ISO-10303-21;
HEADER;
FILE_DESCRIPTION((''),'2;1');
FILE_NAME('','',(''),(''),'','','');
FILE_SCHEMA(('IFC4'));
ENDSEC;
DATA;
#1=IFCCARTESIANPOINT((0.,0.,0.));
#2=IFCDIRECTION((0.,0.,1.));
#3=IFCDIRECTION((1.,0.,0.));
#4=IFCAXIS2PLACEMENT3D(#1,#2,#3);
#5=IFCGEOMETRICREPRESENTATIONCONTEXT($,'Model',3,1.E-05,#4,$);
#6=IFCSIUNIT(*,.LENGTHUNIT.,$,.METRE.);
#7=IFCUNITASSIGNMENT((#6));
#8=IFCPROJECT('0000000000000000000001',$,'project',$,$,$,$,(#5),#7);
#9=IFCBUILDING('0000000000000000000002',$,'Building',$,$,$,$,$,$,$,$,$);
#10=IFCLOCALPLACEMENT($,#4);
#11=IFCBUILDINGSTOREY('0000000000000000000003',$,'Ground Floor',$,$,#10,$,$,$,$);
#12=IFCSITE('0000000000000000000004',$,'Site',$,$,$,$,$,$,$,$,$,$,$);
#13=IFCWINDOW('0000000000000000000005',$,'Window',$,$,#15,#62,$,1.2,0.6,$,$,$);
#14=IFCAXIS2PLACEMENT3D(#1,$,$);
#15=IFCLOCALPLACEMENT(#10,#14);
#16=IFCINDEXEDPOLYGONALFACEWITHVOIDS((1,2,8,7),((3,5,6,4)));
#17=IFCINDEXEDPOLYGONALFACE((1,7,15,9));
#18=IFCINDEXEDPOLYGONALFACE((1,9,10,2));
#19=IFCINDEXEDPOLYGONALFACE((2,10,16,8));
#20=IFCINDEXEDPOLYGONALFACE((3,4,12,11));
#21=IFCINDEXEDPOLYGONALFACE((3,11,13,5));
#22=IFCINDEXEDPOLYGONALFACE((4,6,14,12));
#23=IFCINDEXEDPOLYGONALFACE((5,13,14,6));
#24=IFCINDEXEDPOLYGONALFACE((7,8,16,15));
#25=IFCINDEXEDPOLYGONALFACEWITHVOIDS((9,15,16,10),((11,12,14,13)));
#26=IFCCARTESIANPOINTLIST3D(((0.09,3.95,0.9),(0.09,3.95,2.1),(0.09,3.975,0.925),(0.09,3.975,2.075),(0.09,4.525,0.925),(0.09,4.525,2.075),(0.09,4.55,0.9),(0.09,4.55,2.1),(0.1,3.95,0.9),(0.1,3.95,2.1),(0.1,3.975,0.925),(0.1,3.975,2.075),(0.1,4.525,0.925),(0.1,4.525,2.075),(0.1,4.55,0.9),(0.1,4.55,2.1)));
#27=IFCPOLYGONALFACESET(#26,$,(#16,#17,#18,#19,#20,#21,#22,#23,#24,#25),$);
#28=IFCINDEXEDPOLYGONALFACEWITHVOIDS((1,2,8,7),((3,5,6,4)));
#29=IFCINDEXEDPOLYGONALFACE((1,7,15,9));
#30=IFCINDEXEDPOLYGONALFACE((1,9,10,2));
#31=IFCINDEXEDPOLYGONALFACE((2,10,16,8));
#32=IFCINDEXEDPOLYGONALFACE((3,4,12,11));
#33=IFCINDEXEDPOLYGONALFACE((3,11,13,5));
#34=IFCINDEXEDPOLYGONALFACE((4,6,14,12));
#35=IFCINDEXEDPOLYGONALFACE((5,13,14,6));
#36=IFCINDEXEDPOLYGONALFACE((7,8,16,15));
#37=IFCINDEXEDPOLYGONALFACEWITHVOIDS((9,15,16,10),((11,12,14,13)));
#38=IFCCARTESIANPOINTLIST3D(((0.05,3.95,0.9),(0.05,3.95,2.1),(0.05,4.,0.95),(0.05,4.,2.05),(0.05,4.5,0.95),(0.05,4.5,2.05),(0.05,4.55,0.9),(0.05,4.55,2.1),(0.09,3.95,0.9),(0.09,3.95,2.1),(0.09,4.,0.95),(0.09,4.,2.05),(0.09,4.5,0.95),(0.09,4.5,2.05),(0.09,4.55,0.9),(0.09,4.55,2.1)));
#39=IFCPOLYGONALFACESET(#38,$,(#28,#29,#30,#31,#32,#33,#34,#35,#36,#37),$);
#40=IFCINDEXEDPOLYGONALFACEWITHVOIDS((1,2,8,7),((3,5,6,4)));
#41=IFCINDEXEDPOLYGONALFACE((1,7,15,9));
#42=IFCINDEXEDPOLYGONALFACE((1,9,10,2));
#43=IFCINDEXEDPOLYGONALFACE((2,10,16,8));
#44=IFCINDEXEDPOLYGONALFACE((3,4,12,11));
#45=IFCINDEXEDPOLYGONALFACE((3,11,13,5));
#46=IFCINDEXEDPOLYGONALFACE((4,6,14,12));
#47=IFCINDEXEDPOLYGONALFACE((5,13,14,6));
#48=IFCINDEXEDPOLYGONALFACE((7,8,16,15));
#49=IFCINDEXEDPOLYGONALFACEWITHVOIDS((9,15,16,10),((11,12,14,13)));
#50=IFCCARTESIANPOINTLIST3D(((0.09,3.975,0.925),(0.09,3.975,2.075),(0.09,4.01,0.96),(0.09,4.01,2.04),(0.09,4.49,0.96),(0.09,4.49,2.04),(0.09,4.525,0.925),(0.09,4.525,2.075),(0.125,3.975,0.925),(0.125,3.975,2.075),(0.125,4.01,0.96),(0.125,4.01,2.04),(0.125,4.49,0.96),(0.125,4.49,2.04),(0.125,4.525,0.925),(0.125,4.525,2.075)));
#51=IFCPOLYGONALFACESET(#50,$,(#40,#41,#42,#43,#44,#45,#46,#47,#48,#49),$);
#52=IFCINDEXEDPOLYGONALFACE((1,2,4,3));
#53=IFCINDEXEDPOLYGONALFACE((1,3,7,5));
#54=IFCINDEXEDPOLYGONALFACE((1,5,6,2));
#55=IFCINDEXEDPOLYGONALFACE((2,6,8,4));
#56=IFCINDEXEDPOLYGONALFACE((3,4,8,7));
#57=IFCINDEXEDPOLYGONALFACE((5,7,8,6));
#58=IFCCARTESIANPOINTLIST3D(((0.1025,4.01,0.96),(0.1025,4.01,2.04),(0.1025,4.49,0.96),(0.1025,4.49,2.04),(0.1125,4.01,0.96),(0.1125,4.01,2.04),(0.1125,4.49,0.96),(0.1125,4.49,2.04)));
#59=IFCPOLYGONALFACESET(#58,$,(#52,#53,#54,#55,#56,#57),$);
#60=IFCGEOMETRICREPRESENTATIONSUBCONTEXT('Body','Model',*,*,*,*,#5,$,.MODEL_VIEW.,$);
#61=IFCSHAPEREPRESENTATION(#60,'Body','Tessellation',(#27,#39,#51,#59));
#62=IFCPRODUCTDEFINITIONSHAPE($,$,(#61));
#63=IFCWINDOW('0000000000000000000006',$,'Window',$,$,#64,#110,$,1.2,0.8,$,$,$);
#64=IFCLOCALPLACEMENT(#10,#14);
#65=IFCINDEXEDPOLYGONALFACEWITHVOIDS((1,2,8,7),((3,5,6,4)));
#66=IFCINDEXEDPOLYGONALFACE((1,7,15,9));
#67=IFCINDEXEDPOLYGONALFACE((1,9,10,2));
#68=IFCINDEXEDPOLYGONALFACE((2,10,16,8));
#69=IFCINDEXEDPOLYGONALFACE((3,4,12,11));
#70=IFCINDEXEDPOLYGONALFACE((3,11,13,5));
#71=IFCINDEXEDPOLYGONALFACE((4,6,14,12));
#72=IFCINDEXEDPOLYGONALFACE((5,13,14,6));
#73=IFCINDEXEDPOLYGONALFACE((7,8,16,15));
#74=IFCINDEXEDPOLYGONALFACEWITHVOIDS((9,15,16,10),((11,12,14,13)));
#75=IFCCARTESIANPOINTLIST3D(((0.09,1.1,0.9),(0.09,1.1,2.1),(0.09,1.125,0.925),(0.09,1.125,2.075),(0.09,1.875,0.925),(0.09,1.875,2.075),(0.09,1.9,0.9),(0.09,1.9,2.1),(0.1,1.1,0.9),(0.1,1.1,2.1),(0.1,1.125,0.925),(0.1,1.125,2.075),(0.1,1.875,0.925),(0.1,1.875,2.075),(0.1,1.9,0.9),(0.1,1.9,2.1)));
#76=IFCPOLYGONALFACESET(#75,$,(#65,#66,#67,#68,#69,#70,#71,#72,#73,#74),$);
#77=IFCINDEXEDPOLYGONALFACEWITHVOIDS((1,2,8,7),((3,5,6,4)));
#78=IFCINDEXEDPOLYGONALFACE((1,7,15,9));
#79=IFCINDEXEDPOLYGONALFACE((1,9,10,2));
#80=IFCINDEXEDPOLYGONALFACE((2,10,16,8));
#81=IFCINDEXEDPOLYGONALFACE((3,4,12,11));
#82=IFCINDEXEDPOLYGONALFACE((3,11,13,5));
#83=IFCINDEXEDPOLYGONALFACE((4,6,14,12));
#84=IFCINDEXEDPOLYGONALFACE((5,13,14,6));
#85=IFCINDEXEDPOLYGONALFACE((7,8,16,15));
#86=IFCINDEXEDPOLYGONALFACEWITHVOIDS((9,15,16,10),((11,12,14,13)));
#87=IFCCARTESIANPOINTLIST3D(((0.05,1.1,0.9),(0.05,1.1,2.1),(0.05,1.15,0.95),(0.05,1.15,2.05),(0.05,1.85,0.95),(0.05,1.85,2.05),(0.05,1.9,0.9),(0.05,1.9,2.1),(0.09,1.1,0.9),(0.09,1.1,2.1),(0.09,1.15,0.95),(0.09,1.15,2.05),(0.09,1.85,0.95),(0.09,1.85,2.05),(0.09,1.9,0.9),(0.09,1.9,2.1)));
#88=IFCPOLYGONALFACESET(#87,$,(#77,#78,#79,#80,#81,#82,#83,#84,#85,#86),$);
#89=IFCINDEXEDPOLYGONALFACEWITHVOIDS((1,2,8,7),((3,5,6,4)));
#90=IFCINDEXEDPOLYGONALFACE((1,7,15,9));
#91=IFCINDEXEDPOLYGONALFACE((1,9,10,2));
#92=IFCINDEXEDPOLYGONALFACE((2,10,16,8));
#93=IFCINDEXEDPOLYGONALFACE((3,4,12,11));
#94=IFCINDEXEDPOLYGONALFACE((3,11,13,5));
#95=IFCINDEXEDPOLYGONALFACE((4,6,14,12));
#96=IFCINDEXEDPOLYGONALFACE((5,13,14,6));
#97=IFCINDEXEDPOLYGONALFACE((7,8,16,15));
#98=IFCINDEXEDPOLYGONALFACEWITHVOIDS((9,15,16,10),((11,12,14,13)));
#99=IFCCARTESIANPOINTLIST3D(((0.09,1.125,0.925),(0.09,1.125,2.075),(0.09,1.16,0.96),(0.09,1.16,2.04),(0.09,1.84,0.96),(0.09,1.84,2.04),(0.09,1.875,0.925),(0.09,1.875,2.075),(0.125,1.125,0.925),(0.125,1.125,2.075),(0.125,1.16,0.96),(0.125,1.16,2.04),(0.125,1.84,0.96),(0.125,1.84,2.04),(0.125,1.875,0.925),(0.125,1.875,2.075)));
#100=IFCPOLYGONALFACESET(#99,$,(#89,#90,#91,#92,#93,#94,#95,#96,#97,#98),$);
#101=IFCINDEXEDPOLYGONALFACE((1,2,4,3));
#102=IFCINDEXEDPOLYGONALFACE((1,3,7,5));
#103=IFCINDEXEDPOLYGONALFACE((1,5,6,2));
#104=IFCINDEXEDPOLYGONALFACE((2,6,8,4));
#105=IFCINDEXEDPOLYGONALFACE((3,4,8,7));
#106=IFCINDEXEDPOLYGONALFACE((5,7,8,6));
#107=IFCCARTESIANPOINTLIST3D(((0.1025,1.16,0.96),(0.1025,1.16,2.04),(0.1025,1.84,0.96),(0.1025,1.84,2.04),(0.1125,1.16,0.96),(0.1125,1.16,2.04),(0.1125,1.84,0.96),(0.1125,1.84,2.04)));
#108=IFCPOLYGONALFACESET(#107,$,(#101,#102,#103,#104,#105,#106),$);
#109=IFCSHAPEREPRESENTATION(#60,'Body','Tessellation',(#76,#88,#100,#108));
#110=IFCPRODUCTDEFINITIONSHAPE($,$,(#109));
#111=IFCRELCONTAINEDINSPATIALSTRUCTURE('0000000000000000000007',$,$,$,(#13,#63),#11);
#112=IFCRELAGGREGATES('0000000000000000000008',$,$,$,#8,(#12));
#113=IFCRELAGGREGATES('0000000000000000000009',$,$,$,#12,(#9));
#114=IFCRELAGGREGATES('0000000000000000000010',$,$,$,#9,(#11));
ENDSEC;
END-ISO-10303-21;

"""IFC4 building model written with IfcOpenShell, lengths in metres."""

from ifc_helpers import new_model, si_unit, frame, origin_with_axes, place, context, subcontext, project, spatial, line, indexed_curve, outline, extrude, element, save


model = new_model("IFC4")

# Units and contexts
model_context = context("Model", 3, precision=1e-05, world=origin_with_axes())
body_context = subcontext(model_context, "Body", "Model", "MODEL_VIEW")
ifc_project = project(units=[si_unit("LENGTHUNIT", "METRE")], contexts=[model_context])

# Site, building, storey
site = spatial("IfcSite", under=ifc_project, Name="Site")
building = spatial("IfcBuilding", under=site, Name="Building")
storey_placement = place(None, origin_with_axes())
storey = spatial("IfcBuildingStorey", under=building, at=storey_placement, Name="Ground Floor")

# Windows
window_1_placement = place(storey_placement, frame((0.0, 4.55, 0.9), z_axis=(0.0, 0.0, 1.0), x_axis=(0.0, -1.0, 0.0)))
element("IfcWindow", 1, at=window_1_placement, inside=storey, Name="Window", OverallHeight=1.2, OverallWidth=0.6, context=body_context, shape_type="SweptSolid", body=[
    extrude(outline(indexed_curve([(0.0, 0.0), (0.6, 0.0), (0.6, 1.2), (0.0, 1.2)], segments=[line(1, 2, 3, 4, 1)]), holes=[indexed_curve([(0.025, 0.025), (0.575, 0.025), (0.575, 1.175), (0.025, 1.175)], segments=[line(1, 2, 3, 4, 1)])]), frame((0.0, 0.09, 0.0), z_axis=(0.0, -1.0, 0.0), x_axis=(1.0, 0.0, 0.0)), (0.0, 0.0, -1.0), 0.01),
    extrude(outline(indexed_curve([(0.0, 0.0), (0.6, 0.0), (0.6, 1.2), (0.0, 1.2)], segments=[line(1, 2, 3, 4, 1)]), holes=[indexed_curve([(0.05, 0.05), (0.55, 0.05), (0.55, 1.15), (0.05, 1.15)], segments=[line(1, 2, 3, 4, 1)])]), frame((0.0, 0.05, 0.0), z_axis=(0.0, -1.0, 0.0), x_axis=(1.0, 0.0, 0.0)), (0.0, 0.0, -1.0), 0.04),
    extrude(outline(indexed_curve([(0.0, 0.0), (0.55, 0.0), (0.55, 1.15), (0.0, 1.15)], segments=[line(1, 2, 3, 4, 1)]), holes=[indexed_curve([(0.035, 0.035), (0.515, 0.035), (0.515, 1.115), (0.035, 1.115)], segments=[line(1, 2, 3, 4, 1)])]), frame((0.025, 0.09, 0.025), z_axis=(0.0, -1.0, 0.0), x_axis=(1.0, 0.0, 0.0)), (0.0, 0.0, -1.0), 0.035),
    extrude(outline(indexed_curve([(0.035, 0.035), (0.515, 0.035), (0.515, 1.115), (0.035, 1.115)], segments=[line(1, 2, 3, 4, 1)])), frame((0.025, 0.1025, 0.025), z_axis=(0.0, -1.0, 0.0), x_axis=(1.0, 0.0, 0.0)), (0.0, 0.0, -1.0), 0.01),
])
window_2_placement = place(storey_placement, frame((0.0, 1.9, 0.9), z_axis=(0.0, 0.0, 1.0), x_axis=(0.0, -1.0, 0.0)))
element("IfcWindow", 2, at=window_2_placement, inside=storey, Name="Window", OverallHeight=1.2, OverallWidth=0.8, context=body_context, shape_type="SweptSolid", body=[
    extrude(outline(indexed_curve([(0.0, 0.0), (0.8, 0.0), (0.8, 1.2), (0.0, 1.2)], segments=[line(1, 2, 3, 4, 1)]), holes=[indexed_curve([(0.025, 0.025), (0.775, 0.025), (0.775, 1.175), (0.025, 1.175)], segments=[line(1, 2, 3, 4, 1)])]), frame((0.0, 0.09, 0.0), z_axis=(0.0, -1.0, 0.0), x_axis=(1.0, 0.0, 0.0)), (0.0, 0.0, -1.0), 0.01),
    extrude(outline(indexed_curve([(0.0, 0.0), (0.8, 0.0), (0.8, 1.2), (0.0, 1.2)], segments=[line(1, 2, 3, 4, 1)]), holes=[indexed_curve([(0.05, 0.05), (0.75, 0.05), (0.75, 1.15), (0.05, 1.15)], segments=[line(1, 2, 3, 4, 1)])]), frame((0.0, 0.05, 0.0), z_axis=(0.0, -1.0, 0.0), x_axis=(1.0, 0.0, 0.0)), (0.0, 0.0, -1.0), 0.04),
    extrude(outline(indexed_curve([(0.0, 0.0), (0.75, 0.0), (0.75, 1.15), (0.0, 1.15)], segments=[line(1, 2, 3, 4, 1)]), holes=[indexed_curve([(0.035, 0.035), (0.715, 0.035), (0.715, 1.115), (0.035, 1.115)], segments=[line(1, 2, 3, 4, 1)])]), frame((0.025, 0.09, 0.025), z_axis=(0.0, -1.0, 0.0), x_axis=(1.0, 0.0, 0.0)), (0.0, 0.0, -1.0), 0.035),
    extrude(outline(indexed_curve([(0.035, 0.035), (0.715, 0.035), (0.715, 1.115), (0.035, 1.115)], segments=[line(1, 2, 3, 4, 1)])), frame((0.025, 0.1025, 0.025), z_axis=(0.0, -1.0, 0.0), x_axis=(1.0, 0.0, 0.0)), (0.0, 0.0, -1.0), 0.01),
])

save(model, "model.ifc")
